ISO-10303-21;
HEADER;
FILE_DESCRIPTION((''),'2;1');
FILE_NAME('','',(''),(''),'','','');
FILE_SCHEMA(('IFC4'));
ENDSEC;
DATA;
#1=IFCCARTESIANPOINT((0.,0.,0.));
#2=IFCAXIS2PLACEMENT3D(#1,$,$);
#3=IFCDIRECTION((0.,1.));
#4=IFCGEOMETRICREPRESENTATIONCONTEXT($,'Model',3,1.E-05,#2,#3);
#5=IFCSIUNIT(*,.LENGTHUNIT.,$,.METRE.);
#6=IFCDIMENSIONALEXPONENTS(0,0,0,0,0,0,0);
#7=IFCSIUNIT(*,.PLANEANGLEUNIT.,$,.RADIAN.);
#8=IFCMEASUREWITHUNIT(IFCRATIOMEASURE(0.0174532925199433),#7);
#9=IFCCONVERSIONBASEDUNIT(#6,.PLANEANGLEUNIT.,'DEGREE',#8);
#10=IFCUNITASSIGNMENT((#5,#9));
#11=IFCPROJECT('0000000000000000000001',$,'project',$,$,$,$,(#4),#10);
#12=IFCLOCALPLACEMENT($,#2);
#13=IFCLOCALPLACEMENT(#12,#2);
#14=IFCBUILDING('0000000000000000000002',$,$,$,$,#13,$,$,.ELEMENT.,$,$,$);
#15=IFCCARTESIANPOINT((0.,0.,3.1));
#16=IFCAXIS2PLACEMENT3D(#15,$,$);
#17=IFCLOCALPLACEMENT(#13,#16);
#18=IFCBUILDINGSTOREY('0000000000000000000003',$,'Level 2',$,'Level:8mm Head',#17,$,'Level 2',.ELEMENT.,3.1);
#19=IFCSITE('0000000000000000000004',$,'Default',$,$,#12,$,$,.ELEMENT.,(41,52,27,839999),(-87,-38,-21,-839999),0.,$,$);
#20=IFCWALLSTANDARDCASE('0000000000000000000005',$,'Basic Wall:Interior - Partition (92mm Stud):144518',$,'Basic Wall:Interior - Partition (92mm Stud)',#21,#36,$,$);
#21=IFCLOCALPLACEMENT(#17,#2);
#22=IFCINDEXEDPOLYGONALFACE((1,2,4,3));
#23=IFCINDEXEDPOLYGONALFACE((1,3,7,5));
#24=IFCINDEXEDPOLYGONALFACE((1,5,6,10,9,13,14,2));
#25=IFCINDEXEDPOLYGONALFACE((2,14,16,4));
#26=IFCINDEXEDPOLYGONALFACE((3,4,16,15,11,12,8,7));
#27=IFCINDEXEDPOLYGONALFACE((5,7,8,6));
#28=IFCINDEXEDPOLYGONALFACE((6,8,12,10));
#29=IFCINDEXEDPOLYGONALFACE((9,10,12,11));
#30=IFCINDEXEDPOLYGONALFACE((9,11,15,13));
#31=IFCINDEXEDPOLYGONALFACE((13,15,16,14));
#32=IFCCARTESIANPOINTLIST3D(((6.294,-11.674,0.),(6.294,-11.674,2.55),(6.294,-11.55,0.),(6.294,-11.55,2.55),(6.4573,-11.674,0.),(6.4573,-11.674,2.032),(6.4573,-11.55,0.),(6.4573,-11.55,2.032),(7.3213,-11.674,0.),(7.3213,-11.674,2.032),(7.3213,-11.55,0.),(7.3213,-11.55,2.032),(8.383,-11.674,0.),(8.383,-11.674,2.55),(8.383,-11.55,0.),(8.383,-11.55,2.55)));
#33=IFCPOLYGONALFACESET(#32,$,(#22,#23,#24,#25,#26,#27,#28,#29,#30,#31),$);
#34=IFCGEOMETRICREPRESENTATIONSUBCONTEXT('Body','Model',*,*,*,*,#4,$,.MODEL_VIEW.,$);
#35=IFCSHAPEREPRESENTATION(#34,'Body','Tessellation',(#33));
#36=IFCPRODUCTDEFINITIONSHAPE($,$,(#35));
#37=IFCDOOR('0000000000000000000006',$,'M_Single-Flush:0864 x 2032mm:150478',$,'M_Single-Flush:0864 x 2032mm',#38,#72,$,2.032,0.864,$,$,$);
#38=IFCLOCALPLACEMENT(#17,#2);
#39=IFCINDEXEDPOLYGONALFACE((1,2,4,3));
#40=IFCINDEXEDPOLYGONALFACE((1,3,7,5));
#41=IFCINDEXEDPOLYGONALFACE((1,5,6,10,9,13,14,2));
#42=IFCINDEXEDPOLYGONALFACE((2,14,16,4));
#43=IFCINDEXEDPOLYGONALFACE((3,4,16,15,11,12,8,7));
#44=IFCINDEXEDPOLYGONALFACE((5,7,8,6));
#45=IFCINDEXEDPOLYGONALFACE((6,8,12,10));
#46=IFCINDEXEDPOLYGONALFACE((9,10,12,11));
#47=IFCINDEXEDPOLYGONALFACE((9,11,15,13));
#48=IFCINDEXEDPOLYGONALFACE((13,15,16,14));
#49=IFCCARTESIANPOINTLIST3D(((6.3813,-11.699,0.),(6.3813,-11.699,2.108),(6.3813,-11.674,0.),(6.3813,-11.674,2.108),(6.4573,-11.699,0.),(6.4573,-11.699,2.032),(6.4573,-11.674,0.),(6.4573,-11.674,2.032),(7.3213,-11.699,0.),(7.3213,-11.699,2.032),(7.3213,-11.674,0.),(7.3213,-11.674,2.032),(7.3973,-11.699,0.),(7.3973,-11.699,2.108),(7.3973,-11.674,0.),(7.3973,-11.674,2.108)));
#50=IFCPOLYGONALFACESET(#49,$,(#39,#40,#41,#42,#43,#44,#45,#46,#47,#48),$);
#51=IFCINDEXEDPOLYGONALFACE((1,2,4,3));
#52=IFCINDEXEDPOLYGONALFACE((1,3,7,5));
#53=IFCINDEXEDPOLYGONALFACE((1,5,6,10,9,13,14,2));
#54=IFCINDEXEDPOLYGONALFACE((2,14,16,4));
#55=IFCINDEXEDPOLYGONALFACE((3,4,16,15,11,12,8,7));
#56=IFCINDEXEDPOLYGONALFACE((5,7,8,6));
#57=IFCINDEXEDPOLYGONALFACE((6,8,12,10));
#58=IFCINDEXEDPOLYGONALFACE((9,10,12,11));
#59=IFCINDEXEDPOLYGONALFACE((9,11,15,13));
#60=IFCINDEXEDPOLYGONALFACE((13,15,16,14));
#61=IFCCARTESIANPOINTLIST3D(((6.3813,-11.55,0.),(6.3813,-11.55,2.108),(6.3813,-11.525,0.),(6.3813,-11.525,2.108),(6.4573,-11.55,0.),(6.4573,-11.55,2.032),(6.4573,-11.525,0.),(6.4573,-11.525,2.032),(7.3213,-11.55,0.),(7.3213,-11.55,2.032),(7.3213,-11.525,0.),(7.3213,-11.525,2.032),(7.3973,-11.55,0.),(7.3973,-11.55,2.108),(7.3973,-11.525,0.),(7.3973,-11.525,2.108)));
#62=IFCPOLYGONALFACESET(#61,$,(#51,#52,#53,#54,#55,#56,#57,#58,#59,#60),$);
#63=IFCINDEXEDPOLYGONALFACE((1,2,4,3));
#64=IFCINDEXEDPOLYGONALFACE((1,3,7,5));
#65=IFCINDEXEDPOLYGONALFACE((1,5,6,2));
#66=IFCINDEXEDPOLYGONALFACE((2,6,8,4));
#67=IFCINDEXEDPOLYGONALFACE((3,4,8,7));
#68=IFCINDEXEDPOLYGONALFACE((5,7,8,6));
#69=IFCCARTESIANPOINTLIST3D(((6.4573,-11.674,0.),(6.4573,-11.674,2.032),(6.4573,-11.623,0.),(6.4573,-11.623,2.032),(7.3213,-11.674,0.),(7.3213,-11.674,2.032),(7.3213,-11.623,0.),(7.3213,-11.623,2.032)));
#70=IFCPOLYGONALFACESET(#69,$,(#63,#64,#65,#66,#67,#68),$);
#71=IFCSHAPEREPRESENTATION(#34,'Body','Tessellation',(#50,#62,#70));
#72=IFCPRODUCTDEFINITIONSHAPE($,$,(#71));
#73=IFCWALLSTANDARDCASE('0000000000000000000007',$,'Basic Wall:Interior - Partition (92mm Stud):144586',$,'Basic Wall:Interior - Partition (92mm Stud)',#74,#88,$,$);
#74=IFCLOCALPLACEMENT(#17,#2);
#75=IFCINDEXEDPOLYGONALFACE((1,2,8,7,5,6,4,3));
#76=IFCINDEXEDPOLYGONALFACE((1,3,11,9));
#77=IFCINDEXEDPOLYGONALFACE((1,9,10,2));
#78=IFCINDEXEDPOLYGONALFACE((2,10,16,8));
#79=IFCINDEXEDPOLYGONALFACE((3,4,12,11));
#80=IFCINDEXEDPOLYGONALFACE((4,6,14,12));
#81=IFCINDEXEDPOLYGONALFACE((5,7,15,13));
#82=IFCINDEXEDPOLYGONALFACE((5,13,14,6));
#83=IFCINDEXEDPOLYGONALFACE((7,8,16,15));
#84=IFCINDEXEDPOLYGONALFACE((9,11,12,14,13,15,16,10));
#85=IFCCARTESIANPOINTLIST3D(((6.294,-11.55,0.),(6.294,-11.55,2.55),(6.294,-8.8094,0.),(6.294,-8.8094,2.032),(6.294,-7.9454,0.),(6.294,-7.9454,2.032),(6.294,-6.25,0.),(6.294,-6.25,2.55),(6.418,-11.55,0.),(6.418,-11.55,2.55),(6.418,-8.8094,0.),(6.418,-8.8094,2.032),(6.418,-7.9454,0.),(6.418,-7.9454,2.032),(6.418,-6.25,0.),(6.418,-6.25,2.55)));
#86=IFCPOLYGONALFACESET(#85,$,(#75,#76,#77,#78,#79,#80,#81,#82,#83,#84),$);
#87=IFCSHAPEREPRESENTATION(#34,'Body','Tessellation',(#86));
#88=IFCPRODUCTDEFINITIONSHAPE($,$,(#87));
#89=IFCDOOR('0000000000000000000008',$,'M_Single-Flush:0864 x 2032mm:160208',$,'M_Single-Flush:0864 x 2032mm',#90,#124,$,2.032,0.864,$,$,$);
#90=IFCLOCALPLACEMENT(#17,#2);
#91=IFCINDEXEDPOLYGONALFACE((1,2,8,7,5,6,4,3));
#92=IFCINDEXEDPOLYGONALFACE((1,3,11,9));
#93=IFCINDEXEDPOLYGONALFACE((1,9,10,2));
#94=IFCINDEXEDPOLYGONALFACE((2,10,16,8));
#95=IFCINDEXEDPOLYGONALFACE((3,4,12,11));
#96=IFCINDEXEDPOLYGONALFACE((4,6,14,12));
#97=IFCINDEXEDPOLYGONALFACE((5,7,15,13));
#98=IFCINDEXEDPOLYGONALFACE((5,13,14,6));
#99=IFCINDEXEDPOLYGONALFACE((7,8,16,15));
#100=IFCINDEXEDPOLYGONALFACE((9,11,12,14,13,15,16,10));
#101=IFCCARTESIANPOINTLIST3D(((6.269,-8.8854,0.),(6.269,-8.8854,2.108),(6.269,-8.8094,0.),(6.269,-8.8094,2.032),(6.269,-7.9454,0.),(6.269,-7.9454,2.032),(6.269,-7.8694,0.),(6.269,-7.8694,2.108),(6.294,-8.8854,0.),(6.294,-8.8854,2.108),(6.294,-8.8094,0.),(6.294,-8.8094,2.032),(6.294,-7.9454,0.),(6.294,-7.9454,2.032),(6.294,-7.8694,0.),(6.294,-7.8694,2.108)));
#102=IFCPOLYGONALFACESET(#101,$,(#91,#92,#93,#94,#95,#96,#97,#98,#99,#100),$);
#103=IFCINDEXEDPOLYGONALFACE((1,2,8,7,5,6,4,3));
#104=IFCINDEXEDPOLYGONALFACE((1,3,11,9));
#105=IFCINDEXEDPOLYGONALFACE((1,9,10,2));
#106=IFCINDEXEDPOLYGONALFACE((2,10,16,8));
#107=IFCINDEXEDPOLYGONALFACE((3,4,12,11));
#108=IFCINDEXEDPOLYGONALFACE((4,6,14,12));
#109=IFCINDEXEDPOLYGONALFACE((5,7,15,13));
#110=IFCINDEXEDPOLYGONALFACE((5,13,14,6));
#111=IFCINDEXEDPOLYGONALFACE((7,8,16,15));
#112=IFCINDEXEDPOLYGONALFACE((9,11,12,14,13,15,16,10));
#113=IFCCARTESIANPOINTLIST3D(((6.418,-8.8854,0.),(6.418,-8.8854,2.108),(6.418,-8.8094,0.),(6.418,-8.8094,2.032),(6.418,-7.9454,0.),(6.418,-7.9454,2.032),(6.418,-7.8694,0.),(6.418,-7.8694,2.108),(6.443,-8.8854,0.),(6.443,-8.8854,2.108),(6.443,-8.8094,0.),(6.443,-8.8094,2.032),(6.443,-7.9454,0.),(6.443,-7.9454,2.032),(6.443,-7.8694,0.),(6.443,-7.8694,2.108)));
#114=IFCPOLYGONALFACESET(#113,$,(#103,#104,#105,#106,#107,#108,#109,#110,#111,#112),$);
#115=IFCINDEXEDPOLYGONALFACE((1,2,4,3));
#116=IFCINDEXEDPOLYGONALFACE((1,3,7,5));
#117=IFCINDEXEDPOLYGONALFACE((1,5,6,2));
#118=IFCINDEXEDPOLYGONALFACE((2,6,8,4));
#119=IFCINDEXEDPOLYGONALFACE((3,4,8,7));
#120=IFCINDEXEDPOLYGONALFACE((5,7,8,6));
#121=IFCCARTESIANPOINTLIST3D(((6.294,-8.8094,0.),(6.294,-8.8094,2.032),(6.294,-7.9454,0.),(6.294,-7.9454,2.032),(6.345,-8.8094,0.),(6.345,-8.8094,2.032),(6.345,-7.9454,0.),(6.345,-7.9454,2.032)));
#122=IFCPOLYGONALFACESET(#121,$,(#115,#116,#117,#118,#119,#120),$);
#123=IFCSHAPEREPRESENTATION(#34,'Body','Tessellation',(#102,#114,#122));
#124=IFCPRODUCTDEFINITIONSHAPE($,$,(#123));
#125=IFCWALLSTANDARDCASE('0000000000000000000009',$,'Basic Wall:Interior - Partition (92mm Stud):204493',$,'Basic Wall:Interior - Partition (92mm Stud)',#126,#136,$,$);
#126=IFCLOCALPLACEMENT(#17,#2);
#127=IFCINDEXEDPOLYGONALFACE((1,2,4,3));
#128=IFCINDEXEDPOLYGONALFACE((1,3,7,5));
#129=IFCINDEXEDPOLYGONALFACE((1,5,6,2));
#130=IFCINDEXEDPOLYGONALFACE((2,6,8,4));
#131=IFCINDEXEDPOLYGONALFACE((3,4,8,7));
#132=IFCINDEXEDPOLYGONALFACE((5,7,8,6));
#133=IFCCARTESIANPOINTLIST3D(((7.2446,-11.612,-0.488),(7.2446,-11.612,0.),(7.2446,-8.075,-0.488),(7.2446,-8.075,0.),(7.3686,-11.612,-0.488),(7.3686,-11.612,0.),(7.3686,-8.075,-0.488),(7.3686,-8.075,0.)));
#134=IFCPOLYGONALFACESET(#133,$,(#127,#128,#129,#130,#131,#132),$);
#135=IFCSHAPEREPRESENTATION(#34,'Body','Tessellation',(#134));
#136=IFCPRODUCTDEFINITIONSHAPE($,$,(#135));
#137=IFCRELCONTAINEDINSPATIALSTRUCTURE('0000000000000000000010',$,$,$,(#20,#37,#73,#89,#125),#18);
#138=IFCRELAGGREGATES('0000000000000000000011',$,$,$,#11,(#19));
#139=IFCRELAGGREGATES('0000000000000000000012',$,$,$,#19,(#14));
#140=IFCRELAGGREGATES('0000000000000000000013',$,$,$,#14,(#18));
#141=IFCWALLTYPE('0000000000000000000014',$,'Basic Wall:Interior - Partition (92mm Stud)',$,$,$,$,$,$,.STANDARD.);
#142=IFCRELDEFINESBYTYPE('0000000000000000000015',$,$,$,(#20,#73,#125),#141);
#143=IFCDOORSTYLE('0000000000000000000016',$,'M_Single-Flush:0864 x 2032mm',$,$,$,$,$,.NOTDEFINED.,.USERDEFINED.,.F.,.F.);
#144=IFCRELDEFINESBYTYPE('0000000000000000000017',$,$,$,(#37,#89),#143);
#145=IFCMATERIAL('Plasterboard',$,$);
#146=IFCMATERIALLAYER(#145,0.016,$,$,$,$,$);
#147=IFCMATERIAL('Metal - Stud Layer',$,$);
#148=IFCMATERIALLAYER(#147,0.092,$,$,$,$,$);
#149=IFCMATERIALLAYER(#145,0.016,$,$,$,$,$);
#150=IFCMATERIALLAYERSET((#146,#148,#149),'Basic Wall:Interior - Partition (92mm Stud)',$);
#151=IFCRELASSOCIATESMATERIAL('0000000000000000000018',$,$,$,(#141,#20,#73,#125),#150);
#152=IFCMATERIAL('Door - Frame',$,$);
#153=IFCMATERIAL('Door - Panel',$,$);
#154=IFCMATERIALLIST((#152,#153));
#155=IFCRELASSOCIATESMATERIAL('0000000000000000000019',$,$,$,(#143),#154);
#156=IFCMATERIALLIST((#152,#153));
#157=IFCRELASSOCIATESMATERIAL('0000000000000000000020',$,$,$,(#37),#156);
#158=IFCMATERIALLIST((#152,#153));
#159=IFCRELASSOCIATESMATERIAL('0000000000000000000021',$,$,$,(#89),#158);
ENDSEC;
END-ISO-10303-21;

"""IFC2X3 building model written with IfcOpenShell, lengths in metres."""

from ifc_helpers import new_model, entity, si_unit, converted_unit, direction, frame, frame_2d, origin, origin_2d_with_axis, place, context, subcontext, project, spatial, polyline, rectangle, outline, extrude, source, transform, mapped, material, material_list, layer, layer_set, layer_usage, type_object, type_shapes, element, fill, save


model = new_model("IFC2X3")

# Units and contexts
model_context = context("Model", 3, precision=1e-05, world=origin(), true_north=direction((0.0, 1.0)))
body_context = subcontext(model_context, "Body", "Model", "MODEL_VIEW")
ifc_project = project(units=[si_unit("LENGTHUNIT", "METRE"), converted_unit("PLANEANGLEUNIT", "DEGREE", entity("IfcRatioMeasure", 0.0174532925199433), si_unit("PLANEANGLEUNIT", "RADIAN"), dimensions=[0, 0, 0, 0, 0, 0, 0])], contexts=[model_context])

# Site, building, storey
site_placement = place(None, origin())
site = spatial("IfcSite", under=ifc_project, at=site_placement, Name="Default", CompositionType="ELEMENT", RefLatitude=(41, 52, 27, 839999), RefLongitude=(-87, -38, -21, -839999), RefElevation=0.0)
building_placement = place(site_placement, origin())
building = spatial("IfcBuilding", under=site, at=building_placement, CompositionType="ELEMENT")
storey_placement = place(building_placement, frame((0.0, 0.0, 3.1)))
storey = spatial("IfcBuildingStorey", under=building, at=storey_placement, Name="Level 2", ObjectType="Level:8mm Head", LongName="Level 2", CompositionType="ELEMENT", Elevation=3.1)

# Shared definitions
ifc_material_1 = material(Name="Metal - Stud Layer")
ifc_material_2 = material(Name="Plasterboard")

# Wall, opening, door
ifc_layer_1 = layer(ifc_material_2, 0.016)
ifc_layer_2 = layer(ifc_material_1, 0.092)
ifc_layer_3 = layer(ifc_material_2, 0.016)
ifc_layer_set_1 = layer_set([ifc_layer_1, ifc_layer_2, ifc_layer_3], Name="Basic Wall:Interior - Partition (92mm Stud)")
ifc_layer_usage_1 = layer_usage(ifc_layer_set_1, "AXIS2", "NEGATIVE", 0.062)
wall_type_1 = type_object("IfcWallType", Name="Basic Wall:Interior - Partition (92mm Stud)", PredefinedType="STANDARD", material=ifc_layer_set_1)
wall_1_placement = place(storey_placement, frame((8.383, -11.612, 0.0), z_axis=(0.0, 0.0, 1.0), x_axis=(-1.0, 0.0, 0.0)))
wall_1 = element("IfcWallStandardCase", 1, at=wall_1_placement, inside=storey, type_object=wall_type_1, material=ifc_layer_usage_1, Name="Basic Wall:Interior - Partition (92mm Stud):144518", ObjectType="Basic Wall:Interior - Partition (92mm Stud)", context=body_context, shape_type="SweptSolid", body=[
    extrude(rectangle(XDim=2.089, YDim=0.124, at=frame_2d((1.0445, 0.0), x_axis=(-1.0, 0.0))), origin(), (0.0, 0.0, 1.0), 2.55),
])
opening_1_placement = place(wall_1_placement, frame((1.0617, -0.062, 0.0)))
opening_1 = element("IfcOpeningElement", 2, at=opening_1_placement, cuts=wall_1, ObjectType="Opening", context=body_context, shape_type="SweptSolid", body=[
    extrude(rectangle(XDim=0.864, YDim=2.032, at=frame_2d((1.016, 0.432), x_axis=(0.0, 1.0))), frame((0.0, 0.0, 0.0), z_axis=(0.0, 1.0, 0.0), x_axis=(0.0, 0.0, 1.0)), (0.0, 0.0, 1.0), 0.124),
])
ifc_material_3 = material(Name="Door - Frame")
ifc_material_4 = material(Name="Door - Panel")
ifc_material_list_1 = material_list([ifc_material_3, ifc_material_4])
ifc_material_list_2 = material_list([ifc_material_3, ifc_material_4])
door_style = type_object("IfcDoorStyle", Name="M_Single-Flush:0864 x 2032mm", ConstructionType="USERDEFINED", OperationType="NOTDEFINED", ParameterTakesPrecedence=False, Sizeable=False, material=ifc_material_list_2)
shared_shape_1 = source(origin(), body_context, "Body", "SweptSolid", [
    extrude(outline(polyline([(-0.508, -1.073), (0.508, -1.073), (0.508, 1.035), (0.432, 1.035), (0.432, -0.997), (-0.432, -0.997), (-0.432, 1.035), (-0.508, 1.035), (-0.508, -1.073)])), frame((0.432, 0.124, 1.035), z_axis=(0.0, 1.0, 0.0), x_axis=(1.0, 0.0, 0.0)), (0.0, 0.0, 1.0), 0.025),
    extrude(outline(polyline([(-1.073, -0.508), (1.035, -0.508), (1.035, -0.432), (-0.997, -0.432), (-0.997, 0.432), (1.035, 0.432), (1.035, 0.508), (-1.073, 0.508), (-1.073, -0.508)])), frame((0.432, -0.025, 1.035), z_axis=(0.0, 1.0, 0.0), x_axis=(0.0, 0.0, -1.0)), (0.0, 0.0, 1.0), 0.025),
    extrude(rectangle(XDim=0.051, YDim=0.864, at=origin_2d_with_axis()), frame((0.432, 0.0985, 0.0), z_axis=(0.0, 0.0, 1.0), x_axis=(0.0, 1.0, 0.0)), (0.0, 0.0, 1.0), 2.032),
])
type_shapes(door_style, [shared_shape_1])
door_1_placement = place(opening_1_placement, origin())
door_1 = element("IfcDoor", 3, at=door_1_placement, inside=storey, type_object=door_style, material=ifc_material_list_1, Name="M_Single-Flush:0864 x 2032mm:150478", ObjectType="M_Single-Flush:0864 x 2032mm", OverallHeight=2.032, OverallWidth=0.864, context=body_context, shape_type="MappedRepresentation", body=[
    mapped(shared_shape_1, transform((0.0, 0.0, 0.0), scale=1.0)),
])
fill(opening_1, door_1)

# Wall, openings, door
ifc_layer_usage_2 = layer_usage(ifc_layer_set_1, "AXIS2", "NEGATIVE", 0.062)
wall_2_placement = place(storey_placement, frame((6.356, -11.55, 0.0), z_axis=(0.0, 0.0, 1.0), x_axis=(0.0, 1.0, 0.0)))
wall_2 = element("IfcWallStandardCase", 4, at=wall_2_placement, inside=storey, type_object=wall_type_1, material=ifc_layer_usage_2, Name="Basic Wall:Interior - Partition (92mm Stud):144586", ObjectType="Basic Wall:Interior - Partition (92mm Stud)", context=body_context, shape_type="SweptSolid", body=[
    extrude(rectangle(XDim=5.3, YDim=0.124, at=frame_2d((2.65, 0.0), x_axis=(-1.0, 0.0))), origin(), (0.0, 0.0, 1.0), 2.55),
])
opening_2_placement = place(wall_2_placement, origin())
element("IfcOpeningElement", 5, at=opening_2_placement, cuts=wall_2, ObjectType="Opening", context=body_context, shape_type="SweptSolid", body=[
    extrude(rectangle(XDim=2.032, YDim=0.124, at=frame_2d((0.0, 0.0), x_axis=(0.0, 1.0))), frame((3.7666, 0.0626, 1.016), z_axis=(0.0, 1.0, 0.0), x_axis=(1.0, 0.0, 0.0)), (0.0, 0.0, 1.0), 0.762),
])
opening_3_placement = place(wall_2_placement, frame((2.7406, -0.062, 0.0)))
opening_3 = element("IfcOpeningElement", 6, at=opening_3_placement, cuts=wall_2, ObjectType="Opening", context=body_context, shape_type="SweptSolid", body=[
    extrude(rectangle(XDim=0.864, YDim=2.032, at=frame_2d((1.016, 0.432), x_axis=(0.0, 1.0))), frame((0.0, 0.0, 0.0), z_axis=(0.0, 1.0, 0.0), x_axis=(0.0, 0.0, 1.0)), (0.0, 0.0, 1.0), 0.124),
])
ifc_material_list_3 = material_list([ifc_material_3, ifc_material_4])
door_2_placement = place(opening_3_placement, origin())
door_2 = element("IfcDoor", 7, at=door_2_placement, inside=storey, type_object=door_style, material=ifc_material_list_3, Name="M_Single-Flush:0864 x 2032mm:160208", ObjectType="M_Single-Flush:0864 x 2032mm", OverallHeight=2.032, OverallWidth=0.864, context=body_context, shape_type="MappedRepresentation", body=[
    mapped(shared_shape_1, transform((0.0, 0.0, 0.0), scale=1.0)),
])
fill(opening_3, door_2)

# Wall
ifc_layer_usage_3 = layer_usage(ifc_layer_set_1, "AXIS2", "NEGATIVE", 0.062)
wall_3_placement = place(storey_placement, frame((7.3066, -11.612, -0.488), z_axis=(0.0, 0.0, 1.0), x_axis=(0.0, 1.0, 0.0)))
element("IfcWallStandardCase", 8, at=wall_3_placement, inside=storey, type_object=wall_type_1, material=ifc_layer_usage_3, Name="Basic Wall:Interior - Partition (92mm Stud):204493", ObjectType="Basic Wall:Interior - Partition (92mm Stud)", context=body_context, shape_type="SweptSolid", body=[
    extrude(rectangle(XDim=3.537, YDim=0.124, at=frame_2d((1.7685, 0.0), x_axis=(-1.0, 0.0))), origin(), (0.0, 0.0, 1.0), 0.488),
])

save(model, "model.ifc")
